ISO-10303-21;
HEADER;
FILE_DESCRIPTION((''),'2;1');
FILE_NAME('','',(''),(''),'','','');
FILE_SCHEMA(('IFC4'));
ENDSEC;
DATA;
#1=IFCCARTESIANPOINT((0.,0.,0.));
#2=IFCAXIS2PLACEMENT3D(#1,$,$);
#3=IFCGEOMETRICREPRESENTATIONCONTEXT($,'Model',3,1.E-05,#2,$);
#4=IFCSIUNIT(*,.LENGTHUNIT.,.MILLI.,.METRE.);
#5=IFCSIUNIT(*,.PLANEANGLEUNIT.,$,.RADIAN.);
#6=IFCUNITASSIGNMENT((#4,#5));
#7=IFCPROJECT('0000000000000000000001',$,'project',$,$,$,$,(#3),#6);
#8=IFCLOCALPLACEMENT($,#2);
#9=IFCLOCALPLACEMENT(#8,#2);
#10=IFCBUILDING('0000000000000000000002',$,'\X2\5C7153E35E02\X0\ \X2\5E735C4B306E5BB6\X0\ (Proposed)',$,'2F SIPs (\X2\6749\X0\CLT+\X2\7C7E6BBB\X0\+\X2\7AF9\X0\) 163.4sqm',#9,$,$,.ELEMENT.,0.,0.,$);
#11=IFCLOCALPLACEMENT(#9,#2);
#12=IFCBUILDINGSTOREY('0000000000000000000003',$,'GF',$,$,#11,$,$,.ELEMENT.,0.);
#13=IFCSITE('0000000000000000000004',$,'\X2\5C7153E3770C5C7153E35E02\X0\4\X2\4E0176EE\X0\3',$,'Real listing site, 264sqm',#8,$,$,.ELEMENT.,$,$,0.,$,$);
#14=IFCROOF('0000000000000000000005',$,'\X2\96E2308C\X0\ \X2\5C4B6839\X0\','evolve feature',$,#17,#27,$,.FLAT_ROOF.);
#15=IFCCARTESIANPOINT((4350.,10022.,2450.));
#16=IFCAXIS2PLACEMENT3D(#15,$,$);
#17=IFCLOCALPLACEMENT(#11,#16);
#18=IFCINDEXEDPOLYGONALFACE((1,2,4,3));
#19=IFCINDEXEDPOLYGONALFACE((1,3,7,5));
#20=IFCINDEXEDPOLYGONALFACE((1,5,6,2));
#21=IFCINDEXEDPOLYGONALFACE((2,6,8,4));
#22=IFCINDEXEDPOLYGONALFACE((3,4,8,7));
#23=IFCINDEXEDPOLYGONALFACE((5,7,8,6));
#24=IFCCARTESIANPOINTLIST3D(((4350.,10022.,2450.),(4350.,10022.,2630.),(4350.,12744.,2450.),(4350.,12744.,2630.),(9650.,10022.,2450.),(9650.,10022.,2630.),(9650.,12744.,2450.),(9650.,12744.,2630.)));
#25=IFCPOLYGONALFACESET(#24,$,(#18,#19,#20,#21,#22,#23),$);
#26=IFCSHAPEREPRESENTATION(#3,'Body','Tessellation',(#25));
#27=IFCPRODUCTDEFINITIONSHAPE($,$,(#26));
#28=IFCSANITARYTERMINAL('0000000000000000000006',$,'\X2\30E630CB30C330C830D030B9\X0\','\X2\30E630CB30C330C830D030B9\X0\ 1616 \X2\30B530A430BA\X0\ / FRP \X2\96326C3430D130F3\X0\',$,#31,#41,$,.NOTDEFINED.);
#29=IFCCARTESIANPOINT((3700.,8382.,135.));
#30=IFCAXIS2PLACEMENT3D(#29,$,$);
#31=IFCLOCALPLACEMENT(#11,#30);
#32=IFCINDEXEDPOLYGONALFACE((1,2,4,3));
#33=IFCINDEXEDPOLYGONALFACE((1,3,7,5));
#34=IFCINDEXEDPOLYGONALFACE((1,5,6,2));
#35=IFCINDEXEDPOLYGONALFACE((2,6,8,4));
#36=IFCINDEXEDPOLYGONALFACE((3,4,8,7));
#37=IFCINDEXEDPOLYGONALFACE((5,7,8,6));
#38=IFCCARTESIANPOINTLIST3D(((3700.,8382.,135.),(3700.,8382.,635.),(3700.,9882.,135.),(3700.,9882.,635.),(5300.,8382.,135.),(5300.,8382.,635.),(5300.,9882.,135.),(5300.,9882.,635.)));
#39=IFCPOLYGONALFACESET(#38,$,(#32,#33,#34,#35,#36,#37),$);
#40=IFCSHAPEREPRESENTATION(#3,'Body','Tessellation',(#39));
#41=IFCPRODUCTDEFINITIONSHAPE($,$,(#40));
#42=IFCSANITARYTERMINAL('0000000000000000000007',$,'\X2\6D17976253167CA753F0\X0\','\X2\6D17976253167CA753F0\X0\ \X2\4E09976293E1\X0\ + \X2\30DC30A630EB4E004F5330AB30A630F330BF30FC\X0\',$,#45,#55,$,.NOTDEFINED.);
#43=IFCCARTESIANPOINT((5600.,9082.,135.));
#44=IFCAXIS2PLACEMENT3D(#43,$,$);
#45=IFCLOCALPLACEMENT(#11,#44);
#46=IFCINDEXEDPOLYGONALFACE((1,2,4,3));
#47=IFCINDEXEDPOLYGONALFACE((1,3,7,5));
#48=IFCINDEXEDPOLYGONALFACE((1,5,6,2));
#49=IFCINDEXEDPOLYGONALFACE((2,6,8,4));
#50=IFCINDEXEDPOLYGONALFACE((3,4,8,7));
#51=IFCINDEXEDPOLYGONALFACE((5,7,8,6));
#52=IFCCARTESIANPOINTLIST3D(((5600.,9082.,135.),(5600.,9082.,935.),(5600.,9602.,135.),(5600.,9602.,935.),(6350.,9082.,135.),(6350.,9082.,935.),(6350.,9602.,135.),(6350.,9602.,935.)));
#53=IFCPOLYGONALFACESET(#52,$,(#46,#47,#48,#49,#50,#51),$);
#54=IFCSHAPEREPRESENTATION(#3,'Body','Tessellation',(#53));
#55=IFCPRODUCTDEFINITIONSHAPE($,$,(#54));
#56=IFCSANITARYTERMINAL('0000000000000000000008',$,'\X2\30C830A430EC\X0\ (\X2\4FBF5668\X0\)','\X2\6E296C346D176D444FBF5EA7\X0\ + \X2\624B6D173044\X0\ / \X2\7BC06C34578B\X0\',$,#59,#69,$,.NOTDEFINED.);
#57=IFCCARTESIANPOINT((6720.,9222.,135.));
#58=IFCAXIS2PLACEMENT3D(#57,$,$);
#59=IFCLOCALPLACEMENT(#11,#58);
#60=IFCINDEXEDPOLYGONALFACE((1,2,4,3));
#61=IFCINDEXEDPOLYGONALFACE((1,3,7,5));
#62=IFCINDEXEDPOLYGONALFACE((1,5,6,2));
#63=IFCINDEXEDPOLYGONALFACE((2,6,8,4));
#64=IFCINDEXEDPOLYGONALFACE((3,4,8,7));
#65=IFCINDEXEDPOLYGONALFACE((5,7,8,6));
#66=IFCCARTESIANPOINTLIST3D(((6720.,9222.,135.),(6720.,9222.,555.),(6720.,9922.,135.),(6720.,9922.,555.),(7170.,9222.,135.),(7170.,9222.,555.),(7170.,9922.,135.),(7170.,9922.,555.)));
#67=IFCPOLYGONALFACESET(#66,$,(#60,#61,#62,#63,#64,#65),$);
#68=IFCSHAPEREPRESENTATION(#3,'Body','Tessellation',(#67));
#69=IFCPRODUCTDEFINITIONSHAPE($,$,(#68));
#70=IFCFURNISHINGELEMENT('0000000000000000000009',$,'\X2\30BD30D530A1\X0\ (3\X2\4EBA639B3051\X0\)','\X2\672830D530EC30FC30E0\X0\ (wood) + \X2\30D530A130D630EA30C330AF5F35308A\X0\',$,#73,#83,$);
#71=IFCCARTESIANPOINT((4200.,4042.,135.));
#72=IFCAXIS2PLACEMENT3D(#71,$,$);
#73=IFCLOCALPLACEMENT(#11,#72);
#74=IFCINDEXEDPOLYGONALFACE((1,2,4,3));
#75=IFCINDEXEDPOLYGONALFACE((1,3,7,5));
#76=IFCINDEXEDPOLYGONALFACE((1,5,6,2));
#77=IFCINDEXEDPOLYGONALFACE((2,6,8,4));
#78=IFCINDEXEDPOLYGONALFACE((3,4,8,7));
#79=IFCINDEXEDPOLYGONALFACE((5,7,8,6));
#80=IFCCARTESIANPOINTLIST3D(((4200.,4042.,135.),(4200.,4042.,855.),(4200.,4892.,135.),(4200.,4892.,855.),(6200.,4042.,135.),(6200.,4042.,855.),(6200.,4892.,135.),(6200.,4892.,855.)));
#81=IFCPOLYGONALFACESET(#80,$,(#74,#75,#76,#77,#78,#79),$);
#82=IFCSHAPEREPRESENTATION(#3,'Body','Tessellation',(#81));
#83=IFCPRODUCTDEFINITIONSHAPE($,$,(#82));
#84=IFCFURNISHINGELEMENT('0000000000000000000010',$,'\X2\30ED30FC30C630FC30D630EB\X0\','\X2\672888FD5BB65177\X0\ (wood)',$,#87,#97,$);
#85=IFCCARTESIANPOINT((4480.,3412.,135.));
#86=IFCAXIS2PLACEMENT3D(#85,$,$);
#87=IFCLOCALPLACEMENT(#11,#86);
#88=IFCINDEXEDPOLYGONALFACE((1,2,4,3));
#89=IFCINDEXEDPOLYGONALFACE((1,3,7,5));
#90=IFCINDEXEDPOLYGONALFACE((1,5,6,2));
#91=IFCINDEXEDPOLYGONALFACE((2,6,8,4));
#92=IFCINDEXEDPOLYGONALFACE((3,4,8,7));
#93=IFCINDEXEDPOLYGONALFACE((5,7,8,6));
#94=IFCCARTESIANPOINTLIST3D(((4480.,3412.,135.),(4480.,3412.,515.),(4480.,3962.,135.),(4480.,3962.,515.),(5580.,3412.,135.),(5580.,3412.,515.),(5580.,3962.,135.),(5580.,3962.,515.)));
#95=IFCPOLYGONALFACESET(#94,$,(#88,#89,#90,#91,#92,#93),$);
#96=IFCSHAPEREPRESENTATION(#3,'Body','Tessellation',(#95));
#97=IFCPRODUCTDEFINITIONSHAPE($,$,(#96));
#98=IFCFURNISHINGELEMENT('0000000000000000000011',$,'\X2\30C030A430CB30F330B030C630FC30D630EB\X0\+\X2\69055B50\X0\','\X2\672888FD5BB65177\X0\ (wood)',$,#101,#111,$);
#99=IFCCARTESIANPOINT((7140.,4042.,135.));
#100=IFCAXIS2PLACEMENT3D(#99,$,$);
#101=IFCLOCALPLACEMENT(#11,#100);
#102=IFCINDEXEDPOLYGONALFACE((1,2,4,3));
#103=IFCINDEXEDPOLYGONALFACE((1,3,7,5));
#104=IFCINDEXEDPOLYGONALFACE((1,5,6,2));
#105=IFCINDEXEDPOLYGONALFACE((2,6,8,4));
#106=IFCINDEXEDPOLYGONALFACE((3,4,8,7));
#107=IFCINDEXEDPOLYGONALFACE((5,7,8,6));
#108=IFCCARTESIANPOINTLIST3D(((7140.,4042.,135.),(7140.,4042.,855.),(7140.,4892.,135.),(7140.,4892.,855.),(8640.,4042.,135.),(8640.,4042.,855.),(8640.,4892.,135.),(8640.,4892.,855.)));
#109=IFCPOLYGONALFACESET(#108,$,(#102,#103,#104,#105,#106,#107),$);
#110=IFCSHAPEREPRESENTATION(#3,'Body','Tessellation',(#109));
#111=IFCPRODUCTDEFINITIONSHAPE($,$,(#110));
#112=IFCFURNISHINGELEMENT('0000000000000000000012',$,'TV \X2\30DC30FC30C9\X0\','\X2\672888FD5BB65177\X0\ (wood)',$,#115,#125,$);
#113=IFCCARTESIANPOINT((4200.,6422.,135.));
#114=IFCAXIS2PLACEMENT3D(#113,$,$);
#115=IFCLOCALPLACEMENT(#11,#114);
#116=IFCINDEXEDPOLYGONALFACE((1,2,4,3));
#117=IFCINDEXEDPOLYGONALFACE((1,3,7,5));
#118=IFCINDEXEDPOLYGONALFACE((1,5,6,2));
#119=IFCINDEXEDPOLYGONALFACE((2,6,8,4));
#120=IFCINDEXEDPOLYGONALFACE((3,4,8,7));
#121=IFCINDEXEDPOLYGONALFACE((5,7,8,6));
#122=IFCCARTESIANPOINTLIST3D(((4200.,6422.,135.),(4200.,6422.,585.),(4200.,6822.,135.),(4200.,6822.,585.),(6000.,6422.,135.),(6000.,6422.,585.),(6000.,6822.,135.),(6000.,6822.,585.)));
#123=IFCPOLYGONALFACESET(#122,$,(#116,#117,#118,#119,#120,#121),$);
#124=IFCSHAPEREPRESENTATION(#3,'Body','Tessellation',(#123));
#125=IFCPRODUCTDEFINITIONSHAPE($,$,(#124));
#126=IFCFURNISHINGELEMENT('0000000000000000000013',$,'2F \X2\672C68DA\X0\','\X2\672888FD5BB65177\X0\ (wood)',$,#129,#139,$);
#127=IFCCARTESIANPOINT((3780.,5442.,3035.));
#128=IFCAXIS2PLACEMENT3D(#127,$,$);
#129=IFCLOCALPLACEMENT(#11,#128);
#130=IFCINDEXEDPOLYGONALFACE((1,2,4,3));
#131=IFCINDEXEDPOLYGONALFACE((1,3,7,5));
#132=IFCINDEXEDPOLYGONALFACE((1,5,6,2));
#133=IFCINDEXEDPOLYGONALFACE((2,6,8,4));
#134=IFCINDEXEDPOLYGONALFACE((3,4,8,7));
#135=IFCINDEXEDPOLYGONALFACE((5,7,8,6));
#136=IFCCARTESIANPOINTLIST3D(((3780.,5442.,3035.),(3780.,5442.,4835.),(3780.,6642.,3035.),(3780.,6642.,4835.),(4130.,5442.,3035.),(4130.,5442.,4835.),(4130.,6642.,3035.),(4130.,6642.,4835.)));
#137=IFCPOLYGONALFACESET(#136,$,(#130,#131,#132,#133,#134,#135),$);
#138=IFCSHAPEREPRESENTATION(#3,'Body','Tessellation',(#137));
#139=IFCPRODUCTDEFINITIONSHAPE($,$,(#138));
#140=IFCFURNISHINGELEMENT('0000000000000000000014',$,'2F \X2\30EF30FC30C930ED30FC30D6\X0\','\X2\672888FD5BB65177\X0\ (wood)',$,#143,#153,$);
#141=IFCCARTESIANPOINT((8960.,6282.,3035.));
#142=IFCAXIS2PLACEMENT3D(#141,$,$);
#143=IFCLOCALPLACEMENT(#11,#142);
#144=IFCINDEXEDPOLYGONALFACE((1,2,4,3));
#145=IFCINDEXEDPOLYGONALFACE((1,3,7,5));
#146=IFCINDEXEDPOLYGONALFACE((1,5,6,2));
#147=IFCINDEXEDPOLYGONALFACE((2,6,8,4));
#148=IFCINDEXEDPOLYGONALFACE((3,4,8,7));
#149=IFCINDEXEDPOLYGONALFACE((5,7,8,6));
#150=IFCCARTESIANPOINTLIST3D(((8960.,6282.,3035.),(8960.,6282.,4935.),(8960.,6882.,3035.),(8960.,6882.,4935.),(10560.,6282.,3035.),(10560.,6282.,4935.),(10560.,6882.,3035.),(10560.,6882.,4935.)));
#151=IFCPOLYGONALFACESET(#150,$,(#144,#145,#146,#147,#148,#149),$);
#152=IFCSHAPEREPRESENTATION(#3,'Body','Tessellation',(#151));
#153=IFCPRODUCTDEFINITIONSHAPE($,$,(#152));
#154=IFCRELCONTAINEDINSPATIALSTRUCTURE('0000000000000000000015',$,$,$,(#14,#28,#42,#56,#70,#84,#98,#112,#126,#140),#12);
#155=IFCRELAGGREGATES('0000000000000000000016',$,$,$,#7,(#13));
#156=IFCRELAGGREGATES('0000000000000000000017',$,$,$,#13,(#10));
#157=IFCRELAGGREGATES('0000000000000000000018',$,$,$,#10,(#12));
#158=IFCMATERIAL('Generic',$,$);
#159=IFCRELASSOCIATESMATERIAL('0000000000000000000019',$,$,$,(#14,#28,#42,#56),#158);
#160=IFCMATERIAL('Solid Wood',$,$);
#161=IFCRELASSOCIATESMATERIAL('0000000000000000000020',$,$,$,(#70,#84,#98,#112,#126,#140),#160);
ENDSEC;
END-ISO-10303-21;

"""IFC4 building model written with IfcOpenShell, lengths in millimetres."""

from ifc_helpers import new_model, si_unit, frame, frame_2d, origin, place, context, project, spatial, rectangle, extrude, material, element, save


model = new_model("IFC4")

# Units and contexts
model_context = context("Model", 3, precision=1e-05, world=origin())
ifc_project = project(units=[si_unit("LENGTHUNIT", "METRE", prefix="MILLI"), si_unit("PLANEANGLEUNIT", "RADIAN")], contexts=[model_context])

# Site, building, storey
site_placement = place(None, origin())
site = spatial("IfcSite", under=ifc_project, at=site_placement, Name="山口県山口市4丁目3", ObjectType="Real listing site, 264sqm", CompositionType="ELEMENT", RefElevation=0.0)
building_placement = place(site_placement, origin())
building = spatial("IfcBuilding", under=site, at=building_placement, Name="山口市 平屋の家 (Proposed)", ObjectType="2F SIPs (杉CLT+籾殻+竹) 163.4sqm", CompositionType="ELEMENT", ElevationOfRefHeight=0.0, ElevationOfTerrain=0.0)
storey_placement = place(building_placement, origin())
storey = spatial("IfcBuildingStorey", under=building, at=storey_placement, Name="GF", CompositionType="ELEMENT", Elevation=0.0)

# Shared definitions
ifc_material_1 = material(Name="Generic")

# Shared definitions
ifc_material_2 = material(Name="Solid Wood")

# Roof
roof_placement = place(storey_placement, frame((4350.0, 10022.0, 2450.0)))
element("IfcRoof", 1, at=roof_placement, inside=storey, material=ifc_material_1, Name="離れ 屋根", Description="evolve feature", PredefinedType="FLAT_ROOF", context=model_context, shape_type="SweptSolid", body=[
    extrude(rectangle(XDim=5300.0, YDim=2722.0, at=frame_2d((2650.0, 1361.0))), frame((4350.0, 10022.0, 2450.0)), (0.0, 0.0, 1.0), 180.0),
])

# Sanitary terminals
sanitary_terminal_1_placement = place(storey_placement, frame((3700.0, 8382.0, 135.0)))
element("IfcSanitaryTerminal", 2, at=sanitary_terminal_1_placement, inside=storey, material=ifc_material_1, Name="ユニットバス", Description="ユニットバス 1616 サイズ / FRP 防水パン", PredefinedType="NOTDEFINED", context=model_context, shape_type="SweptSolid", body=[
    extrude(rectangle(XDim=1600.0, YDim=1500.0, at=frame_2d((800.0, 750.0))), frame((3700.0, 8382.0, 135.0)), (0.0, 0.0, 1.0), 500.0),
])
sanitary_terminal_2_placement = place(storey_placement, frame((5600.0, 9082.0, 135.0)))
element("IfcSanitaryTerminal", 3, at=sanitary_terminal_2_placement, inside=storey, material=ifc_material_1, Name="洗面化粧台", Description="洗面化粧台 三面鏡 + ボウル一体カウンター", PredefinedType="NOTDEFINED", context=model_context, shape_type="SweptSolid", body=[
    extrude(rectangle(XDim=750.0, YDim=520.0, at=frame_2d((375.0, 260.0))), frame((5600.0, 9082.0, 135.0)), (0.0, 0.0, 1.0), 800.0),
])
sanitary_terminal_3_placement = place(storey_placement, frame((6720.0, 9222.0, 135.0)))
element("IfcSanitaryTerminal", 4, at=sanitary_terminal_3_placement, inside=storey, material=ifc_material_1, Name="トイレ (便器)", Description="温水洗浄便座 + 手洗い / 節水型", PredefinedType="NOTDEFINED", context=model_context, shape_type="SweptSolid", body=[
    extrude(rectangle(XDim=450.0, YDim=700.0, at=frame_2d((225.0, 350.0))), frame((6720.0, 9222.0, 135.0)), (0.0, 0.0, 1.0), 420.0),
])

# Furnishing elements
furnishing_1_placement = place(storey_placement, frame((4200.0, 4042.0, 135.0)))
element("IfcFurnishingElement", 5, at=furnishing_1_placement, inside=storey, material=ifc_material_2, Name="ソファ (3人掛け)", Description="木フレーム (wood) + ファブリック張り", context=model_context, shape_type="SweptSolid", body=[
    extrude(rectangle(XDim=2000.0, YDim=850.0, at=frame_2d((1000.0, 425.0))), frame((4200.0, 4042.0, 135.0)), (0.0, 0.0, 1.0), 720.0),
])
furnishing_2_placement = place(storey_placement, frame((4480.0, 3412.0, 135.0)))
element("IfcFurnishingElement", 6, at=furnishing_2_placement, inside=storey, material=ifc_material_2, Name="ローテーブル", Description="木製家具 (wood)", context=model_context, shape_type="SweptSolid", body=[
    extrude(rectangle(XDim=1100.0, YDim=550.0, at=frame_2d((550.0, 275.0))), frame((4480.0, 3412.0, 135.0)), (0.0, 0.0, 1.0), 380.0),
])
furnishing_3_placement = place(storey_placement, frame((7140.0, 4042.0, 135.0)))
element("IfcFurnishingElement", 7, at=furnishing_3_placement, inside=storey, material=ifc_material_2, Name="ダイニングテーブル+椅子", Description="木製家具 (wood)", context=model_context, shape_type="SweptSolid", body=[
    extrude(rectangle(XDim=1500.0, YDim=850.0, at=frame_2d((750.0, 425.0))), frame((7140.0, 4042.0, 135.0)), (0.0, 0.0, 1.0), 720.0),
])
furnishing_4_placement = place(storey_placement, frame((4200.0, 6422.0, 135.0)))
element("IfcFurnishingElement", 8, at=furnishing_4_placement, inside=storey, material=ifc_material_2, Name="TV ボード", Description="木製家具 (wood)", context=model_context, shape_type="SweptSolid", body=[
    extrude(rectangle(XDim=1800.0, YDim=400.0, at=frame_2d((900.0, 200.0))), frame((4200.0, 6422.0, 135.0)), (0.0, 0.0, 1.0), 450.0),
])
furnishing_5_placement = place(storey_placement, frame((3780.0, 5442.0, 3035.0)))
element("IfcFurnishingElement", 9, at=furnishing_5_placement, inside=storey, material=ifc_material_2, Name="2F 本棚", Description="木製家具 (wood)", context=model_context, shape_type="SweptSolid", body=[
    extrude(rectangle(XDim=350.0, YDim=1200.0, at=frame_2d((175.0, 600.0))), frame((3780.0, 5442.0, 3035.0)), (0.0, 0.0, 1.0), 1800.0),
])
furnishing_6_placement = place(storey_placement, frame((8960.0, 6282.0, 3035.0)))
element("IfcFurnishingElement", 10, at=furnishing_6_placement, inside=storey, material=ifc_material_2, Name="2F ワードローブ", Description="木製家具 (wood)", context=model_context, shape_type="SweptSolid", body=[
    extrude(rectangle(XDim=1600.0, YDim=600.0, at=frame_2d((800.0, 300.0))), frame((8960.0, 6282.0, 3035.0)), (0.0, 0.0, 1.0), 1900.0),
])

save(model, "model.ifc")
